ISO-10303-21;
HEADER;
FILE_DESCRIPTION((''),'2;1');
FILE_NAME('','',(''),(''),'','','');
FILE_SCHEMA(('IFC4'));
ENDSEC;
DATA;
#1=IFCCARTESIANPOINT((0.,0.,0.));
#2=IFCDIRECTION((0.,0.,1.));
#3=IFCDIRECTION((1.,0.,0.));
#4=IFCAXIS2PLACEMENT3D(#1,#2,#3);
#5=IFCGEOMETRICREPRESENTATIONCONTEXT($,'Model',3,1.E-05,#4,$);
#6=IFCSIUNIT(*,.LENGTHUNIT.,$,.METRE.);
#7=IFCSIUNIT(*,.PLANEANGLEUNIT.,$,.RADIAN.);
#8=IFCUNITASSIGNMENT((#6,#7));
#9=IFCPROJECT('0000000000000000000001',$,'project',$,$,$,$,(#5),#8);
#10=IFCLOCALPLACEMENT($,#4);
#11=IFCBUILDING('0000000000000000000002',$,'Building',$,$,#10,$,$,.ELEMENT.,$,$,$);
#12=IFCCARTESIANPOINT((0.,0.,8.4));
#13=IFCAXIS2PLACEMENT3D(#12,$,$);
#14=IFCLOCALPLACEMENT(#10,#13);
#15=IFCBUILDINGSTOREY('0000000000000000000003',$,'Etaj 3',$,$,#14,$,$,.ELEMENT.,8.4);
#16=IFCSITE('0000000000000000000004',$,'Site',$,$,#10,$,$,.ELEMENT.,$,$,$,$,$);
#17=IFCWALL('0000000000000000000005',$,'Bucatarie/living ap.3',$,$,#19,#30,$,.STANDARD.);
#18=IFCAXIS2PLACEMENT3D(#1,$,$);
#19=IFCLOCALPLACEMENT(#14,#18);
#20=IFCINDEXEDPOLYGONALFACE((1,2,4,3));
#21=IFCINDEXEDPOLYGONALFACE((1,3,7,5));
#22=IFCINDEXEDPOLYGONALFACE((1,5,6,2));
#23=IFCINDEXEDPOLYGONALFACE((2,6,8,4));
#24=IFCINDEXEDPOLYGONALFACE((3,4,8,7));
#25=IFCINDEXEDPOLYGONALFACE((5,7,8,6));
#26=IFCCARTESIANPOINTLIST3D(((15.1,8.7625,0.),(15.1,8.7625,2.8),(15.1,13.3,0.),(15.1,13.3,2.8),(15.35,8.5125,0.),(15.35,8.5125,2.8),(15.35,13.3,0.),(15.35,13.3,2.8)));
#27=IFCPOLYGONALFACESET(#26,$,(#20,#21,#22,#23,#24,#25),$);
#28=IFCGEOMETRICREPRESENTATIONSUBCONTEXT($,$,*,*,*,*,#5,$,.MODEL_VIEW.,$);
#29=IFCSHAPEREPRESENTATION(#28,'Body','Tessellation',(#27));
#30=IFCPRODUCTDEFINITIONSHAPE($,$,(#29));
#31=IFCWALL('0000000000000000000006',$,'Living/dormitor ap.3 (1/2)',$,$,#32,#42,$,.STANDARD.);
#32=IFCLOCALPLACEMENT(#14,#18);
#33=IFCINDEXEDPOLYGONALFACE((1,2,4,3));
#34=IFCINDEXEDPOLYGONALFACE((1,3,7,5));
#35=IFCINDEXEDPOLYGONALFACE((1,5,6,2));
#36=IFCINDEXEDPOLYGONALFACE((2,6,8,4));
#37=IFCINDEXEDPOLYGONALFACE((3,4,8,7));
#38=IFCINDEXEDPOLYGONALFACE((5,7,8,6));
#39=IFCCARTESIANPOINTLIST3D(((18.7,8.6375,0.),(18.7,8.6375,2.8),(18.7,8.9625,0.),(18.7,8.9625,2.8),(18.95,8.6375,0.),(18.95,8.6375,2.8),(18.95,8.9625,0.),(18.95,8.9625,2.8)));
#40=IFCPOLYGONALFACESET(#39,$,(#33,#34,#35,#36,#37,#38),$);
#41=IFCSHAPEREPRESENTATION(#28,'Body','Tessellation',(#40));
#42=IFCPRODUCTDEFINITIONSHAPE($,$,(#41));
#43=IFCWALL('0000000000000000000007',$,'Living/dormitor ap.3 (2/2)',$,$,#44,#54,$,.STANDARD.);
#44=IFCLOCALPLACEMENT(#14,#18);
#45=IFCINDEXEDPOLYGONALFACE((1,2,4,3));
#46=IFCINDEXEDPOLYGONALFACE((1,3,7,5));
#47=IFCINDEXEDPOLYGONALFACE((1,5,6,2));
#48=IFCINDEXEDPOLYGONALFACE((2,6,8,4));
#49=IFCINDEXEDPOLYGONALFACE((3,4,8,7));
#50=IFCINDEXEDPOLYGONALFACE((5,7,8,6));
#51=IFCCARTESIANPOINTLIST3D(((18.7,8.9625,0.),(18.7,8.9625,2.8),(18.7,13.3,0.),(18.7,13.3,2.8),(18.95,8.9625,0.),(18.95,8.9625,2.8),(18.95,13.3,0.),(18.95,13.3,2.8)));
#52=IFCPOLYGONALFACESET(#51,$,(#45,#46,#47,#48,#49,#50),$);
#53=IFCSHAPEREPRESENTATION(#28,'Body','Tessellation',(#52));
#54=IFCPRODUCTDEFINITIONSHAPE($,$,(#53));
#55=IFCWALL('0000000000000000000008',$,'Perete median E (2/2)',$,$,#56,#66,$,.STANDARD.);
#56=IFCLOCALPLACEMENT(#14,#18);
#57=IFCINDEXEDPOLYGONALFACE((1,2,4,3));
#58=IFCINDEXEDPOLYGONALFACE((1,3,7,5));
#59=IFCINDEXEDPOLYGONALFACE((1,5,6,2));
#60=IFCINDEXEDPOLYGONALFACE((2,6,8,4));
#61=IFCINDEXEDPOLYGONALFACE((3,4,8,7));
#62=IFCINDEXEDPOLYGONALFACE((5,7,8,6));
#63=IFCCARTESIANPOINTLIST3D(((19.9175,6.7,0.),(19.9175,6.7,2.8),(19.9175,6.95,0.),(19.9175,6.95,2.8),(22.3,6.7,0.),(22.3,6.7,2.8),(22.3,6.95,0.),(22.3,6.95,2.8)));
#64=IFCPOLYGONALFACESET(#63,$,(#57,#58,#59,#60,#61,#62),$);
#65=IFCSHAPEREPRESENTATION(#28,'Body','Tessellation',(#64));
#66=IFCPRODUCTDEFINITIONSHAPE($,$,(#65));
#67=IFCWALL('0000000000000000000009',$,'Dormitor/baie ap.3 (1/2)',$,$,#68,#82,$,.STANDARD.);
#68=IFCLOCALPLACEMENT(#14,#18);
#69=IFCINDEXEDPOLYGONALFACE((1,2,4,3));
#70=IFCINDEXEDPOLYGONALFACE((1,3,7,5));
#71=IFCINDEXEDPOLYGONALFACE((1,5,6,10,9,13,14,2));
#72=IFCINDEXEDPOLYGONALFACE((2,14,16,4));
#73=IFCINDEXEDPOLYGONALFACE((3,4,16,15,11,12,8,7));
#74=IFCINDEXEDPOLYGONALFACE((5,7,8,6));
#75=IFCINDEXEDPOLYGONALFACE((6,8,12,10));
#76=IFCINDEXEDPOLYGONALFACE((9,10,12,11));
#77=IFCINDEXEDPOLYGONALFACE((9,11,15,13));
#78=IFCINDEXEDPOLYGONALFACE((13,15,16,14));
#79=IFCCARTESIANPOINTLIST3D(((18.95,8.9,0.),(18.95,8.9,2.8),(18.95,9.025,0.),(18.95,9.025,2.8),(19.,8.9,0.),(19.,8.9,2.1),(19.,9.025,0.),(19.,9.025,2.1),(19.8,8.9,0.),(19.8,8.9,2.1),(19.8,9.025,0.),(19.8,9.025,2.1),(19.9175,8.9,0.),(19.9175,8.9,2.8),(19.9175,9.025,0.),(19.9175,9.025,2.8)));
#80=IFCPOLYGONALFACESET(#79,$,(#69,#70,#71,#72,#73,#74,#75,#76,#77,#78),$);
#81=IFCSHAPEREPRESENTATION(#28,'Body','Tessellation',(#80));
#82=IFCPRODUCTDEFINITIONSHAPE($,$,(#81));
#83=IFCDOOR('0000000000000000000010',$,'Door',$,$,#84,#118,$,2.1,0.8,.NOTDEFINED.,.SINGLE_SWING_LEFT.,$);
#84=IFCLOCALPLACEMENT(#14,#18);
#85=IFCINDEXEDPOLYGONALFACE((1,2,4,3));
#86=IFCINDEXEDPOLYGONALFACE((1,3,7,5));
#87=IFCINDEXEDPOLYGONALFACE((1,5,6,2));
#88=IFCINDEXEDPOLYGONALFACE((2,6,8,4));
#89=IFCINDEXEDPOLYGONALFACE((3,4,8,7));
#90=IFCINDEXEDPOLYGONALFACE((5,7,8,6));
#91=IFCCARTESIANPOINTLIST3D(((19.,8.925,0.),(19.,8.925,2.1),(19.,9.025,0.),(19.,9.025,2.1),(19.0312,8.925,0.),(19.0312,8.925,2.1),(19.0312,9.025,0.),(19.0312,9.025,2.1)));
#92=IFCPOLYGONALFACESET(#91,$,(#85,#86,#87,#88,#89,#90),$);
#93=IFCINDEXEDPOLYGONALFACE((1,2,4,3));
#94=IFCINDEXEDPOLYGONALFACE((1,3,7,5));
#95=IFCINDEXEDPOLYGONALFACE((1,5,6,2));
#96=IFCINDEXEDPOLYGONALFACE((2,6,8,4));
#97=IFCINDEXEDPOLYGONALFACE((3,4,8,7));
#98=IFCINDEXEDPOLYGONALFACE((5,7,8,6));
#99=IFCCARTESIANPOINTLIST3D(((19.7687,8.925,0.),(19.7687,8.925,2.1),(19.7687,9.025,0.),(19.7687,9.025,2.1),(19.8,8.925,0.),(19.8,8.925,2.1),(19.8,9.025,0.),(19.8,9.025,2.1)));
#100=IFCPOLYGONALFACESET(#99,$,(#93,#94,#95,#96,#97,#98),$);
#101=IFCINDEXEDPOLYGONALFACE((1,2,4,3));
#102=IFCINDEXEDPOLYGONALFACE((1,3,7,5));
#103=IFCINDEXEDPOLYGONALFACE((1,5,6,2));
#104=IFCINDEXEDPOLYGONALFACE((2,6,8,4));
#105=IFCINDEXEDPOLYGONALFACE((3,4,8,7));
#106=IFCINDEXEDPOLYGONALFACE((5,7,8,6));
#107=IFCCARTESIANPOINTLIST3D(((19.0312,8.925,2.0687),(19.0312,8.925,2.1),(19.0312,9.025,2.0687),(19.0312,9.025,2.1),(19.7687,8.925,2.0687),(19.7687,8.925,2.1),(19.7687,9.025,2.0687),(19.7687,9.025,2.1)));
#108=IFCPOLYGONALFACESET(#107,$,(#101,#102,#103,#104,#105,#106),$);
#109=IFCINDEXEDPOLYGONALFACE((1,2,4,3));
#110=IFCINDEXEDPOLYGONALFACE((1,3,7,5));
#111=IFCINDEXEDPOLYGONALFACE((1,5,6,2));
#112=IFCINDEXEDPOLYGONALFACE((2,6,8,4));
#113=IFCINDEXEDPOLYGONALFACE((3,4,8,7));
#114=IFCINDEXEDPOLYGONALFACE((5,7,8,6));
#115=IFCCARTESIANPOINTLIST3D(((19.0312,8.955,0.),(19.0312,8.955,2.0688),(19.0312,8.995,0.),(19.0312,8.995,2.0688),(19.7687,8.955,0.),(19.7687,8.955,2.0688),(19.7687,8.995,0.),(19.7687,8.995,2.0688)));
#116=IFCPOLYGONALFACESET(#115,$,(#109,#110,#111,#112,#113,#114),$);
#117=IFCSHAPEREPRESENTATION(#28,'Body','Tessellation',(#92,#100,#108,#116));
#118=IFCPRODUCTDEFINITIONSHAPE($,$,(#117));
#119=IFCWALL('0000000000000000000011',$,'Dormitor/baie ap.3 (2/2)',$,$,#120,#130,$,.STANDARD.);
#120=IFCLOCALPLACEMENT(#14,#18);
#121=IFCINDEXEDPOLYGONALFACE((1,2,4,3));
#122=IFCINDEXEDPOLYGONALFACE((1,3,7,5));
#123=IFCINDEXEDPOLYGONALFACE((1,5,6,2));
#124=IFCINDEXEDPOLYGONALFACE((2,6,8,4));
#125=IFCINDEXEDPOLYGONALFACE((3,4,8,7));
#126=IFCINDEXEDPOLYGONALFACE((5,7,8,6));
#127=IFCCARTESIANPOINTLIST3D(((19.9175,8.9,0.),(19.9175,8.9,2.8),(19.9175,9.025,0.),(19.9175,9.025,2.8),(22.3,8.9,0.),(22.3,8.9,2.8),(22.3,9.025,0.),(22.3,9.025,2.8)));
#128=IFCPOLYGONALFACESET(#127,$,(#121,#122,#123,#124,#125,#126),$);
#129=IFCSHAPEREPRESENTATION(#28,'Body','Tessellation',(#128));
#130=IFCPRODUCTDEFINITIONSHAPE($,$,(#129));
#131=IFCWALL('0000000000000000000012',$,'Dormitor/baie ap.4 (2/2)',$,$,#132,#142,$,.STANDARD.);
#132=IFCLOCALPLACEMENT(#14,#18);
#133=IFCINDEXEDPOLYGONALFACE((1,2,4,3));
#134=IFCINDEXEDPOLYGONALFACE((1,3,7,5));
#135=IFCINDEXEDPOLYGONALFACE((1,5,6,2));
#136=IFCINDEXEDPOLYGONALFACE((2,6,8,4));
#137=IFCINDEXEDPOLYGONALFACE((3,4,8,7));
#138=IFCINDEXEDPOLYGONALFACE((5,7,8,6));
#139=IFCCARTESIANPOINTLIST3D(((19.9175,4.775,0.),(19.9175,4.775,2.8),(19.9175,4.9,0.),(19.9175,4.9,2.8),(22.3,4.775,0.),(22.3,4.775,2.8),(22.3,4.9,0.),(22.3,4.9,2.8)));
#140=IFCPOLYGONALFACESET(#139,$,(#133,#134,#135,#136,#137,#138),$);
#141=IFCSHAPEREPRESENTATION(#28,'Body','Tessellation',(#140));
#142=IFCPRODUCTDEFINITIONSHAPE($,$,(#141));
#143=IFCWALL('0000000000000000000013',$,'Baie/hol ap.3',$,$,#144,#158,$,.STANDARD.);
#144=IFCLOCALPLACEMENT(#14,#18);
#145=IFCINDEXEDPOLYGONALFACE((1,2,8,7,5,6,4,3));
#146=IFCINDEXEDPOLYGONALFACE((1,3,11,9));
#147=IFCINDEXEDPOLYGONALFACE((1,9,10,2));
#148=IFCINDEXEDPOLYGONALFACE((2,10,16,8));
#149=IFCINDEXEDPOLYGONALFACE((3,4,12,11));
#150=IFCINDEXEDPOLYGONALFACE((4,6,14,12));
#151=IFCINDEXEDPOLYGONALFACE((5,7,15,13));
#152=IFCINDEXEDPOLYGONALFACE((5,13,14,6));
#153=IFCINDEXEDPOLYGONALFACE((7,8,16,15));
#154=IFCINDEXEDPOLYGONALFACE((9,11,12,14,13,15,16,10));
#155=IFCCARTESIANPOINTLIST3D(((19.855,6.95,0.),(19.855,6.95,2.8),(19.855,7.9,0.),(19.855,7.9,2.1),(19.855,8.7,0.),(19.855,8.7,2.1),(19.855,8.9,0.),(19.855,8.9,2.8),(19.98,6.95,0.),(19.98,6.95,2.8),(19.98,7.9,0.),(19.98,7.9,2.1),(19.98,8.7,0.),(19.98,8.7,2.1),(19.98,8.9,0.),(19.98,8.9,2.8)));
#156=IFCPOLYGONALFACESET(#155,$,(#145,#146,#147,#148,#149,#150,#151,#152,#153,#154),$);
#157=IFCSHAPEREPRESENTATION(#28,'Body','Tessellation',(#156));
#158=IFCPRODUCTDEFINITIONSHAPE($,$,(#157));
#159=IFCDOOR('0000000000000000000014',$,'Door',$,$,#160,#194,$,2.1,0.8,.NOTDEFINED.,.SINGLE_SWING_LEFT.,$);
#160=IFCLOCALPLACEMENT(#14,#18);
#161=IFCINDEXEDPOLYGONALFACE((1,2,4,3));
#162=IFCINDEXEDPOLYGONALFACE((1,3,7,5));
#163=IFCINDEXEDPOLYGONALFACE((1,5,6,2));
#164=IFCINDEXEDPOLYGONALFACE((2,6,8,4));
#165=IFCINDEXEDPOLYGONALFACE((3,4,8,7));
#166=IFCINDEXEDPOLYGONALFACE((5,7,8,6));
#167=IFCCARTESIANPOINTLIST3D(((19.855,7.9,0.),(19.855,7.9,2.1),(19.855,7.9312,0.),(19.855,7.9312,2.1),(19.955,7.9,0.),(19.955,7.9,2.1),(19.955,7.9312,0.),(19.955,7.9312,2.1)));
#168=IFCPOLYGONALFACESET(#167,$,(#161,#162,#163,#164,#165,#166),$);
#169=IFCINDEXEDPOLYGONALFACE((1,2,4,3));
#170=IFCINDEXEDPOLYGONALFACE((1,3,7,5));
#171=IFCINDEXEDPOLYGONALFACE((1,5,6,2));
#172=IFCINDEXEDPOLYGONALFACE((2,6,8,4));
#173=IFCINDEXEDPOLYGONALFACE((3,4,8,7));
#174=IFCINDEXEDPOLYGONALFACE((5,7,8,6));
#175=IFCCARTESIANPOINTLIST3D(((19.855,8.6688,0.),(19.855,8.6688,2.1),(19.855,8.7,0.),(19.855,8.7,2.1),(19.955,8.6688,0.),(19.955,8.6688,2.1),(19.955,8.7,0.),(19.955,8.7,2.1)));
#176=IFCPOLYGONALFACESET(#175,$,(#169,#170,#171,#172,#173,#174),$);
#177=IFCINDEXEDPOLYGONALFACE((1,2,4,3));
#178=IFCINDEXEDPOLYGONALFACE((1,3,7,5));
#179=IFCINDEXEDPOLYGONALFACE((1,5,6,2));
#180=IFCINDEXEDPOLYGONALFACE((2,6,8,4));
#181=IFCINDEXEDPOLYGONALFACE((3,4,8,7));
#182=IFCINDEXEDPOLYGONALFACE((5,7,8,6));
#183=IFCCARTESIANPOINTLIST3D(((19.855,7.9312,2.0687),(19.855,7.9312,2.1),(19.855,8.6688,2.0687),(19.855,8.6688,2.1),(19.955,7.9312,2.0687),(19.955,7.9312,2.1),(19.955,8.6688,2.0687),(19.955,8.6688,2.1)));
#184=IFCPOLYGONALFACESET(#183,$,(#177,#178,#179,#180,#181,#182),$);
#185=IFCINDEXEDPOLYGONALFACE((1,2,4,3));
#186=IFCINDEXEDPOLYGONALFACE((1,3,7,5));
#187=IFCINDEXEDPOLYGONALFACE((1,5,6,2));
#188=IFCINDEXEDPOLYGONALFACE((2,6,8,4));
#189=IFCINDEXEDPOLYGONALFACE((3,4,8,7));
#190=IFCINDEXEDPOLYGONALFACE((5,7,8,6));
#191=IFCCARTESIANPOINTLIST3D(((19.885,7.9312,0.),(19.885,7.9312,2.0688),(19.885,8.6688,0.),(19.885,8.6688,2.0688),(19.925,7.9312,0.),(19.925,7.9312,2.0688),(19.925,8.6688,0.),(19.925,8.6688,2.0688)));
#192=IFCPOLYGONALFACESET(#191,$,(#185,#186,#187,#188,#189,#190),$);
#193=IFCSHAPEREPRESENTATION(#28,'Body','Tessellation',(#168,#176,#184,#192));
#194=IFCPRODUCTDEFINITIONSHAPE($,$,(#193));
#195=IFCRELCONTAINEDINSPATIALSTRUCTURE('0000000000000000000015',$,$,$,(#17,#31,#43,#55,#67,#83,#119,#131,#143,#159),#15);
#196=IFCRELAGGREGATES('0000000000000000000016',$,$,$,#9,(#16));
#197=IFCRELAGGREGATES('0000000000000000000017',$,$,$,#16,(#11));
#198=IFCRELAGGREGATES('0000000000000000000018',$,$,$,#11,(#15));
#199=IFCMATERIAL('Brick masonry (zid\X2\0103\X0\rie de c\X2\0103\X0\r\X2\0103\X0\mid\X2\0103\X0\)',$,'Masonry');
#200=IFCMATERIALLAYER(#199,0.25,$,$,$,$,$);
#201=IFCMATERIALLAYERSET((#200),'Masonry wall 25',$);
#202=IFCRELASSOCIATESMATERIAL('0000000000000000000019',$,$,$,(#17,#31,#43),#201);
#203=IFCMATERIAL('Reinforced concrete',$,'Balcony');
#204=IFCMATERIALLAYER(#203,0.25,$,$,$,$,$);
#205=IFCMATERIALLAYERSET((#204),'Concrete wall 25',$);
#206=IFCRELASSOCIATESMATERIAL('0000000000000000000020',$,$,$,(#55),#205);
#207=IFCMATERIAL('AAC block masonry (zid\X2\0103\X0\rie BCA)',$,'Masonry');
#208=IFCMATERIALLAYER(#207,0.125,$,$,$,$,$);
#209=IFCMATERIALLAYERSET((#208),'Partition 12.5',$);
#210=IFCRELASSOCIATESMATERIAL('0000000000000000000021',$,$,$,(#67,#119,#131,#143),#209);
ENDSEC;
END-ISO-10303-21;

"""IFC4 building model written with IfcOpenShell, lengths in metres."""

from ifc_helpers import new_model, si_unit, frame, frame_2d, origin, origin_with_axes, origin_2d, place, context, subcontext, project, spatial, rectangle, extrude, clip, halfspace, material, layer, layer_set, layer_usage, element, fill, save


model = new_model("IFC4")

# Units and contexts
model_context = context("Model", 3, precision=1e-05, world=origin_with_axes())
sub_context = subcontext(model_context, None, None, "MODEL_VIEW")
ifc_project = project(units=[si_unit("LENGTHUNIT", "METRE"), si_unit("PLANEANGLEUNIT", "RADIAN")], contexts=[model_context])

# Site, building, storey
placement = place(None, origin_with_axes())
site = spatial("IfcSite", under=ifc_project, at=placement, Name="Site", CompositionType="ELEMENT")
building = spatial("IfcBuilding", under=site, at=placement, Name="Building", CompositionType="ELEMENT")
storey_placement = place(placement, frame((0.0, 0.0, 8.4)))
storey = spatial("IfcBuildingStorey", under=building, at=storey_placement, Name="Etaj 3", CompositionType="ELEMENT", Elevation=8.4)

# Shared definitions
ifc_material_1 = material(Name="Brick masonry (zidărie de cărămidă)", Category="Masonry")

# Walls
ifc_layer_1 = layer(ifc_material_1, 0.25)
ifc_layer_set_1 = layer_set([ifc_layer_1], Name="Masonry wall 25")
ifc_layer_usage_1 = layer_usage(ifc_layer_set_1, "AXIS2", "POSITIVE", -0.125)
wall_1_placement = place(storey_placement, frame((15.225, 8.5125, 0.0), x_axis=(0.0, 1.0, 0.0)))
element("IfcWall", 1, at=wall_1_placement, inside=storey, material=ifc_layer_usage_1, Name="Bucatarie/living ap.3", PredefinedType="STANDARD", context=sub_context, shape_type="CSG", body=[
    clip(extrude(rectangle(XDim=4.7875, YDim=0.25, at=frame_2d((2.3938, 0.0))), origin(), (0.0, 0.0, 1.0), 2.8), halfspace(frame((0.125, 0.0, 0.0), z_axis=(-0.707107, 0.707107, 0.0)), False)),
])
wall_2_placement = place(storey_placement, frame((18.825, 8.6375, 0.0), x_axis=(0.0, 1.0, 0.0)))
element("IfcWall", 2, at=wall_2_placement, inside=storey, material=ifc_layer_usage_1, Name="Living/dormitor ap.3 (1/2)", PredefinedType="STANDARD", context=sub_context, shape_type="SweptSolid", body=[
    extrude(rectangle(XDim=0.325, YDim=0.25, at=frame_2d((0.1625, 0.0))), origin(), (0.0, 0.0, 1.0), 2.8),
])
wall_3_placement = place(storey_placement, frame((18.825, 8.9625, 0.0), x_axis=(0.0, 1.0, 0.0)))
element("IfcWall", 3, at=wall_3_placement, inside=storey, material=ifc_layer_usage_1, Name="Living/dormitor ap.3 (2/2)", PredefinedType="STANDARD", context=sub_context, shape_type="SweptSolid", body=[
    extrude(rectangle(XDim=4.3375, YDim=0.25, at=frame_2d((2.1688, 0.0))), origin(), (0.0, 0.0, 1.0), 2.8),
])
ifc_material_2 = material(Name="Reinforced concrete", Category="Balcony")
ifc_layer_2 = layer(ifc_material_2, 0.25)
ifc_layer_set_2 = layer_set([ifc_layer_2], Name="Concrete wall 25")
ifc_layer_usage_2 = layer_usage(ifc_layer_set_2, "AXIS2", "POSITIVE", -0.125)
wall_4_placement = place(storey_placement, frame((19.9175, 6.825, 0.0), x_axis=(1.0, 0.0, 0.0)))
element("IfcWall", 4, at=wall_4_placement, inside=storey, material=ifc_layer_usage_2, Name="Perete median E (2/2)", PredefinedType="STANDARD", context=sub_context, shape_type="SweptSolid", body=[
    extrude(rectangle(XDim=2.3825, YDim=0.25, at=frame_2d((1.1913, 0.0))), origin(), (0.0, 0.0, 1.0), 2.8),
])

# Wall, opening, door
ifc_material_3 = material(Name="AAC block masonry (zidărie BCA)", Category="Masonry")
ifc_layer_3 = layer(ifc_material_3, 0.125)
ifc_layer_set_3 = layer_set([ifc_layer_3], Name="Partition 12.5")
ifc_layer_usage_3 = layer_usage(ifc_layer_set_3, "AXIS2", "POSITIVE", -0.0625)
wall_5_placement = place(storey_placement, frame((18.95, 8.9625, 0.0), x_axis=(1.0, 0.0, 0.0)))
wall_5 = element("IfcWall", 5, at=wall_5_placement, inside=storey, material=ifc_layer_usage_3, Name="Dormitor/baie ap.3 (1/2)", PredefinedType="STANDARD", context=sub_context, shape_type="SweptSolid", body=[
    extrude(rectangle(XDim=0.9675, YDim=0.125, at=frame_2d((0.4838, 0.0))), origin(), (0.0, 0.0, 1.0), 2.8),
])
opening_1_placement = place(wall_5_placement, frame((0.45, 0.1125, 0.0), z_axis=(0.0, -1.0, 0.0), x_axis=(1.0, 0.0, 0.0)))
opening_1 = element("IfcOpeningElement", 6, at=opening_1_placement, cuts=wall_5, PredefinedType="OPENING", context=sub_context, shape_type="SweptSolid", body=[
    extrude(rectangle(XDim=0.8, YDim=2.1, at=frame_2d((0.0, 1.05))), origin(), (0.0, 0.0, 1.0), 0.225),
])
door_1_placement = place(wall_5_placement, frame((0.45, 0.0625, 0.0), z_axis=(0.0, -1.0, 0.0), x_axis=(1.0, 0.0, 0.0)))
door_1 = element("IfcDoor", 7, at=door_1_placement, inside=storey, Name="Door", OperationType="SINGLE_SWING_LEFT", OverallHeight=2.1, OverallWidth=0.8, PredefinedType="NOTDEFINED", context=sub_context, shape_type="SweptSolid", body=[
    extrude(rectangle(XDim=0.0312, YDim=2.1, at=origin_2d()), frame((-0.3844, 1.05, 0.0)), (0.0, 0.0, 1.0), 0.1),
    extrude(rectangle(XDim=0.0312, YDim=2.1, at=origin_2d()), frame((0.3844, 1.05, 0.0)), (0.0, 0.0, 1.0), 0.1),
    extrude(rectangle(XDim=0.7375, YDim=0.0312, at=origin_2d()), frame((0.0, 2.0844, 0.0)), (0.0, 0.0, 1.0), 0.1),
    extrude(rectangle(XDim=0.7375, YDim=2.0688, at=origin_2d()), frame((0.0, 1.0344, 0.03)), (0.0, 0.0, 1.0), 0.04),
])
fill(opening_1, door_1)

# Walls
for number, where, x_axis, name in (
    (8, (19.9175, 8.9625, 0.0), (1.0, 0.0, 0.0), "Dormitor/baie ap.3 (2/2)"),
    (9, (19.9175, 4.8375, 0.0), (1.0, 0.0, 0.0), "Dormitor/baie ap.4 (2/2)"),
):
    element("IfcWall", number, at=place(storey_placement, frame(where, x_axis=x_axis)), inside=storey, material=ifc_layer_usage_3, Name=name, PredefinedType="STANDARD", context=sub_context, shape_type="SweptSolid", body=[
        extrude(rectangle(XDim=2.3825, YDim=0.125, at=frame_2d((1.1913, 0.0))), origin(), (0.0, 0.0, 1.0), 2.8),
    ])

# Wall, opening, door
wall_6_placement = place(storey_placement, frame((19.9175, 6.95, 0.0), x_axis=(0.0, 1.0, 0.0)))
wall_6 = element("IfcWall", 10, at=wall_6_placement, inside=storey, material=ifc_layer_usage_3, Name="Baie/hol ap.3", PredefinedType="STANDARD", context=sub_context, shape_type="SweptSolid", body=[
    extrude(rectangle(XDim=1.95, YDim=0.125, at=frame_2d((0.975, 0.0))), origin(), (0.0, 0.0, 1.0), 2.8),
])
opening_2_placement = place(wall_6_placement, frame((1.35, 0.1125, 0.0), z_axis=(0.0, -1.0, 0.0), x_axis=(1.0, 0.0, 0.0)))
opening_2 = element("IfcOpeningElement", 11, at=opening_2_placement, cuts=wall_6, PredefinedType="OPENING", context=sub_context, shape_type="SweptSolid", body=[
    extrude(rectangle(XDim=0.8, YDim=2.1, at=frame_2d((0.0, 1.05))), origin(), (0.0, 0.0, 1.0), 0.225),
])
door_2_placement = place(wall_6_placement, frame((1.35, 0.0625, 0.0), z_axis=(0.0, -1.0, 0.0), x_axis=(1.0, 0.0, 0.0)))
door_2 = element("IfcDoor", 12, at=door_2_placement, inside=storey, Name="Door", OperationType="SINGLE_SWING_LEFT", OverallHeight=2.1, OverallWidth=0.8, PredefinedType="NOTDEFINED", context=sub_context, shape_type="SweptSolid", body=[
    extrude(rectangle(XDim=0.0312, YDim=2.1, at=origin_2d()), frame((-0.3844, 1.05, 0.0)), (0.0, 0.0, 1.0), 0.1),
    extrude(rectangle(XDim=0.0312, YDim=2.1, at=origin_2d()), frame((0.3844, 1.05, 0.0)), (0.0, 0.0, 1.0), 0.1),
    extrude(rectangle(XDim=0.7375, YDim=0.0312, at=origin_2d()), frame((0.0, 2.0844, 0.0)), (0.0, 0.0, 1.0), 0.1),
    extrude(rectangle(XDim=0.7375, YDim=2.0688, at=origin_2d()), frame((0.0, 1.0344, 0.03)), (0.0, 0.0, 1.0), 0.04),
])
fill(opening_2, door_2)

save(model, "model.ifc")
